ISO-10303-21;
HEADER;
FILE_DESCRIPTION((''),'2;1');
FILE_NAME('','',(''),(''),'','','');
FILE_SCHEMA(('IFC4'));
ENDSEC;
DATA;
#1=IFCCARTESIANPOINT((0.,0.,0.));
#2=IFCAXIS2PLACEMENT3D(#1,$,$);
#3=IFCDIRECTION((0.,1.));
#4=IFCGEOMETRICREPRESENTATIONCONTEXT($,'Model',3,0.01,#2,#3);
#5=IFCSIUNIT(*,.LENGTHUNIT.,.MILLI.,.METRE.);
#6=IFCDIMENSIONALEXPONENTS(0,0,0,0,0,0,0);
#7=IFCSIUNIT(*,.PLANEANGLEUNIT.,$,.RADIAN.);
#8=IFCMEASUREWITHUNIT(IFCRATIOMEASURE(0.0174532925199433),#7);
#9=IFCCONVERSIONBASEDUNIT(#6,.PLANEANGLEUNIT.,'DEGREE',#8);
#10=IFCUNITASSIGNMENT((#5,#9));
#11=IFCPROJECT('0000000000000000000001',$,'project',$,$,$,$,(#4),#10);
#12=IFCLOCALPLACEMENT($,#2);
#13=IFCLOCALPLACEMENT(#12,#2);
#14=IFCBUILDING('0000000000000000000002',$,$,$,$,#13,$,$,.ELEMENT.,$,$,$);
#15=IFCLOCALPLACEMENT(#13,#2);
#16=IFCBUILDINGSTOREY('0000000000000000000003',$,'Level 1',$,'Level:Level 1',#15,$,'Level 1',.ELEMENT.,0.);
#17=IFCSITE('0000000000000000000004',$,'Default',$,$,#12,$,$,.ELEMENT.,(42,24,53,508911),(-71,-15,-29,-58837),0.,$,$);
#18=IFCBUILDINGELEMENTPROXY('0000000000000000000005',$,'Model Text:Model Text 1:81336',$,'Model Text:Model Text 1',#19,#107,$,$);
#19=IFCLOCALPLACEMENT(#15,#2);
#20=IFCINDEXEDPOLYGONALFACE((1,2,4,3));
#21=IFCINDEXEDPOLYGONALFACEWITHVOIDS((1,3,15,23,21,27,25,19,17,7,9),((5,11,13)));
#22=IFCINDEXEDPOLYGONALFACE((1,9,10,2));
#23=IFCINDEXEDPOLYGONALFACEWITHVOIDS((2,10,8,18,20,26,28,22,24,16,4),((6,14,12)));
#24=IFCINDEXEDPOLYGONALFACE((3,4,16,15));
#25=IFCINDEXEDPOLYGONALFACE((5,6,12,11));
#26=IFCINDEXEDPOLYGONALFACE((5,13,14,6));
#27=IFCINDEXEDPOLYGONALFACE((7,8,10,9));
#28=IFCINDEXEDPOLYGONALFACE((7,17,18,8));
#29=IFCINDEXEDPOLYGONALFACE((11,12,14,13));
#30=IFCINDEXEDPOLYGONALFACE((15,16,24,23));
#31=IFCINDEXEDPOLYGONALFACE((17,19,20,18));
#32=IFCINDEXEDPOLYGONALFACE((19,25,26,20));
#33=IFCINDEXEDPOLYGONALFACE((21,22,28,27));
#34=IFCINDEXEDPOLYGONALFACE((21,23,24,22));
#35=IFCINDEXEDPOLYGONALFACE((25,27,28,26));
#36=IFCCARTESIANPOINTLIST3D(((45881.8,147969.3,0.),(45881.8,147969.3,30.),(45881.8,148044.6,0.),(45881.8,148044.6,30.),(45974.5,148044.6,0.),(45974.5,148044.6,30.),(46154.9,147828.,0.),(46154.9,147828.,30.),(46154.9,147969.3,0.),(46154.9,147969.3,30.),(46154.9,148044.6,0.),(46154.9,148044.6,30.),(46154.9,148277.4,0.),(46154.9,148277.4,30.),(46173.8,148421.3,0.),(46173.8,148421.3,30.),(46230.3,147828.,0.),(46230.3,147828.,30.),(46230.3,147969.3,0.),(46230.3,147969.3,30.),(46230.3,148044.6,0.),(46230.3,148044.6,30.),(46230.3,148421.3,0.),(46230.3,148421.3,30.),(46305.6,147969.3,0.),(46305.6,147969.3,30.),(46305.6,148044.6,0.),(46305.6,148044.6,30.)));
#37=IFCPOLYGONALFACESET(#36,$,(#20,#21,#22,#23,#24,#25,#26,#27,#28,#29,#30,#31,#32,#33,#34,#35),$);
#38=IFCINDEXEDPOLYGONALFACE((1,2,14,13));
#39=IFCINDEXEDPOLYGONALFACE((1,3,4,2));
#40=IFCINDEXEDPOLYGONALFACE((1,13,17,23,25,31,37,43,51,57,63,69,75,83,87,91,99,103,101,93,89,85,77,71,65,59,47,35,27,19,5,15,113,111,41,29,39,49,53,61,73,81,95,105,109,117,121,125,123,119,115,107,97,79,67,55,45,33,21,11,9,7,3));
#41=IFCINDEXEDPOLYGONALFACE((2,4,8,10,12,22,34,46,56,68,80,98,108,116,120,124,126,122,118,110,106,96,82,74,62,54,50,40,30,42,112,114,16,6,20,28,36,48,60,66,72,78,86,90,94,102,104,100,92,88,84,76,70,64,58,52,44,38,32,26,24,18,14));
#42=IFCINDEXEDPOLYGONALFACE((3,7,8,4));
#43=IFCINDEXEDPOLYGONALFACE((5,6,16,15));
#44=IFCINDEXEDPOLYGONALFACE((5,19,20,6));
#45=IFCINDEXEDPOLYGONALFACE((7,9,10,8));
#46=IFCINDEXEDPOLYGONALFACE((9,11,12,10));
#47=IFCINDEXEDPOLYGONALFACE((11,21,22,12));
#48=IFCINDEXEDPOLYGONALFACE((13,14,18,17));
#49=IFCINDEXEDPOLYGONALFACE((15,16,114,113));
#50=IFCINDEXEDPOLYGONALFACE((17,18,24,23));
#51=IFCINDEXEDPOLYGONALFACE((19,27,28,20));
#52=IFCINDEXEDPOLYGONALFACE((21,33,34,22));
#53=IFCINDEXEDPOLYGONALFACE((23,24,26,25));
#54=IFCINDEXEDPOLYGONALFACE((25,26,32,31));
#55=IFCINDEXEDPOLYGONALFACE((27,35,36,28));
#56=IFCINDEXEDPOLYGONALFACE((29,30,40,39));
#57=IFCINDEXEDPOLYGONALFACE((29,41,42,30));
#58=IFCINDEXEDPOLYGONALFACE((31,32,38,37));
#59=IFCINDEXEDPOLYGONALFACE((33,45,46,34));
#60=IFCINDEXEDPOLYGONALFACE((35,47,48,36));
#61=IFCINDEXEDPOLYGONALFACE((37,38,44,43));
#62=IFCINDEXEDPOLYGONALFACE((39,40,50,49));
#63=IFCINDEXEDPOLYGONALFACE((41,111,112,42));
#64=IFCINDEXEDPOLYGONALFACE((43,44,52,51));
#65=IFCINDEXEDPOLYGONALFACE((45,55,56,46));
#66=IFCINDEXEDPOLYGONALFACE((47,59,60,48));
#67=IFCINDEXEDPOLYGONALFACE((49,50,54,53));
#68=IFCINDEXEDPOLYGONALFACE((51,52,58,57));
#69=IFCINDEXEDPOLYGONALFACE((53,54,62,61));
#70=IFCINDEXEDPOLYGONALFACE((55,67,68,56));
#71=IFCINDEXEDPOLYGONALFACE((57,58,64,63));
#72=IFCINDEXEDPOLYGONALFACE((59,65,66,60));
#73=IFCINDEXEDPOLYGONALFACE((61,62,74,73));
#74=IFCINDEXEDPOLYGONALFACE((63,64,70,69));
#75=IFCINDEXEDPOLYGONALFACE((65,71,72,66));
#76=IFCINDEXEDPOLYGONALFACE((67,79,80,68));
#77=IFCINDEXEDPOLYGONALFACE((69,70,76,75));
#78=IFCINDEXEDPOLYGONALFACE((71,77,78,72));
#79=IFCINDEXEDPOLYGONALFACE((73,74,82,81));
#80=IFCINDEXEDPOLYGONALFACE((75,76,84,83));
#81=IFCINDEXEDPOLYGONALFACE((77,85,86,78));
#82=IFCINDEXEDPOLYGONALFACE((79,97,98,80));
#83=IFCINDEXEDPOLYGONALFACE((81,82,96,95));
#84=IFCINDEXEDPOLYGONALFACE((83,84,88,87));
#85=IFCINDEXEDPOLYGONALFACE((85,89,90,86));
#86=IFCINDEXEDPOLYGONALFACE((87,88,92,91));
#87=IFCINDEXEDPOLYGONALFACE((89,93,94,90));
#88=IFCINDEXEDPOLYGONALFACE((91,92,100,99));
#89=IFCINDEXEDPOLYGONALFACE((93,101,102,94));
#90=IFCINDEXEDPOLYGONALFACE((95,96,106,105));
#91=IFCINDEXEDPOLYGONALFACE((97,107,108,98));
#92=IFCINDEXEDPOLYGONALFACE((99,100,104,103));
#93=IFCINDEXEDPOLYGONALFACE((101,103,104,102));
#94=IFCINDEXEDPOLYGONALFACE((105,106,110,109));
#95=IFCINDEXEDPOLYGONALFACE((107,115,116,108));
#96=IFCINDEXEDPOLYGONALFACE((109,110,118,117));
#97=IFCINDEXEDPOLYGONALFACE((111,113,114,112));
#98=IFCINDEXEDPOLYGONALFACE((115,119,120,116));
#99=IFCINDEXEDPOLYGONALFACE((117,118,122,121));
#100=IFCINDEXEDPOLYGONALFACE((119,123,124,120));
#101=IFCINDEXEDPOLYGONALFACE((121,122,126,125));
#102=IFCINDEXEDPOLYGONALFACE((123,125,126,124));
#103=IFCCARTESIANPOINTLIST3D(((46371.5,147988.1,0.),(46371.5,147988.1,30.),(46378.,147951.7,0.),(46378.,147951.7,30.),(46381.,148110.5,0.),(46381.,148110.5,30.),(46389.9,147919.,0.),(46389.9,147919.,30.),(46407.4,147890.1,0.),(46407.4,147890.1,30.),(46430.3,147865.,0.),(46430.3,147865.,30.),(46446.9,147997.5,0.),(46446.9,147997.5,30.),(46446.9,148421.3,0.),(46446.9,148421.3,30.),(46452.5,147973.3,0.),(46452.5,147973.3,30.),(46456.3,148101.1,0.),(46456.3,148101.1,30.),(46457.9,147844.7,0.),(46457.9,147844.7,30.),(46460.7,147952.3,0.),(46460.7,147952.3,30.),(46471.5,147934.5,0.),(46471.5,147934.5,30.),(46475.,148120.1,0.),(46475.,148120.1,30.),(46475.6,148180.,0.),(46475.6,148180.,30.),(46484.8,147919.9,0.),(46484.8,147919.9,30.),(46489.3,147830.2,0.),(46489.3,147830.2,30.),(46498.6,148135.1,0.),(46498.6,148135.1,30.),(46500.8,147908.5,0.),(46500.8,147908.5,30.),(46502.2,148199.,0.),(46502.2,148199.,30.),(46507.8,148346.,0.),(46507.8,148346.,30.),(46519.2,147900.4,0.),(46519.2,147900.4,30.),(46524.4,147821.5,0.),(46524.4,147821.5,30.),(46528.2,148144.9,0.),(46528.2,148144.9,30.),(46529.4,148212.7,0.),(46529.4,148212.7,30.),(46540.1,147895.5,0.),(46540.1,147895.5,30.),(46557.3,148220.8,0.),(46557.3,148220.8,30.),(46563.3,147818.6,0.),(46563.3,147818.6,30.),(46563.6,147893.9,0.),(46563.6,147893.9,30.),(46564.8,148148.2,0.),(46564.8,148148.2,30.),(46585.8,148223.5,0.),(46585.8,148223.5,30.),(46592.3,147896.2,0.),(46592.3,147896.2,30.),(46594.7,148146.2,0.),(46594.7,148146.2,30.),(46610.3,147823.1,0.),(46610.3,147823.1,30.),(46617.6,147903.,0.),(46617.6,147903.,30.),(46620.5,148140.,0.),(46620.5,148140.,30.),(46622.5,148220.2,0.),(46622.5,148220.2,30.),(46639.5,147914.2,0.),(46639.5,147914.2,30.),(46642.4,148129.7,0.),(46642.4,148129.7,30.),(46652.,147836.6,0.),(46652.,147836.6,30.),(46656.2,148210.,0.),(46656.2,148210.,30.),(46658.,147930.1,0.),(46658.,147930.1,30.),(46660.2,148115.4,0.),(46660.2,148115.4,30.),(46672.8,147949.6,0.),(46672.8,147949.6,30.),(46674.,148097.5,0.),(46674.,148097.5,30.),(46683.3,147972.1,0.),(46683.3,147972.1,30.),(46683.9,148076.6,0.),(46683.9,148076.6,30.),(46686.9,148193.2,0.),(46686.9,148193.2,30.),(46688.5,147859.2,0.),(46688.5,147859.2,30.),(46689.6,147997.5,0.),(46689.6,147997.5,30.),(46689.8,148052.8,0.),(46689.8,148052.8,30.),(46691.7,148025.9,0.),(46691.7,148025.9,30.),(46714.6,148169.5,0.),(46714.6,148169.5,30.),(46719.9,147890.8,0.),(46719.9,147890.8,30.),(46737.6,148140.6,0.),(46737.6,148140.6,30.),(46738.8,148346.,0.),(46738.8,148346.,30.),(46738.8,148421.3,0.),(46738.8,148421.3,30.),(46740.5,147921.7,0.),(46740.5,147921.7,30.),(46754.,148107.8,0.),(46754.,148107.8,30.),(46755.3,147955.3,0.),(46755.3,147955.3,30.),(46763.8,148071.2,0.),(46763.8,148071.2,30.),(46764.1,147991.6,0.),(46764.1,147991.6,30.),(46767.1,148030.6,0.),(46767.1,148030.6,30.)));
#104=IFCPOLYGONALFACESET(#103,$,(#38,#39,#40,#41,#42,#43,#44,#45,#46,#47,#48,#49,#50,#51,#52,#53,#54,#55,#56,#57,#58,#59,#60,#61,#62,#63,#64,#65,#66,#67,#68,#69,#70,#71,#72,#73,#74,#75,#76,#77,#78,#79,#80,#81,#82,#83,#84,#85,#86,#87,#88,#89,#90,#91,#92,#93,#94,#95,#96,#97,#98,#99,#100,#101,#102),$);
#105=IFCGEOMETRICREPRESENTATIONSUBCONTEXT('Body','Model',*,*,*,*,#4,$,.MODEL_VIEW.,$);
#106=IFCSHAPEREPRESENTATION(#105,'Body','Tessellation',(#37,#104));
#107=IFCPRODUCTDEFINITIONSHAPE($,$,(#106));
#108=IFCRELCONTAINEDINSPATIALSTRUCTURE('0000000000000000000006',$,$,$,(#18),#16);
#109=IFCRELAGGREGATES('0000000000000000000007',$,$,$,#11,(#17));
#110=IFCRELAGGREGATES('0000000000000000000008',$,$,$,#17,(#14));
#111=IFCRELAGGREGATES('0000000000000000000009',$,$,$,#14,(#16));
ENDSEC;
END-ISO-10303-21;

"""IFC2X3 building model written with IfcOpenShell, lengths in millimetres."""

from ifc_helpers import new_model, entity, si_unit, converted_unit, direction, frame, origin, place, context, subcontext, project, spatial, polyline, outline, extrude, element, save


model = new_model("IFC2X3")

# Units and contexts
model_context = context("Model", 3, precision=0.01, world=origin(), true_north=direction((0.0, 1.0)))
body_context = subcontext(model_context, "Body", "Model", "MODEL_VIEW")
ifc_project = project(units=[si_unit("LENGTHUNIT", "METRE", prefix="MILLI"), converted_unit("PLANEANGLEUNIT", "DEGREE", entity("IfcRatioMeasure", 0.0174532925199433), si_unit("PLANEANGLEUNIT", "RADIAN"), dimensions=[0, 0, 0, 0, 0, 0, 0])], contexts=[model_context])

# Site, building, storey
site_placement = place(None, origin())
site = spatial("IfcSite", under=ifc_project, at=site_placement, Name="Default", CompositionType="ELEMENT", RefLatitude=(42, 24, 53, 508911), RefLongitude=(-71, -15, -29, -58837), RefElevation=0.0)
building_placement = place(site_placement, origin())
building = spatial("IfcBuilding", under=site, at=building_placement, CompositionType="ELEMENT")
storey_placement = place(building_placement, origin())
storey = spatial("IfcBuildingStorey", under=building, at=storey_placement, Name="Level 1", ObjectType="Level:Level 1", LongName="Level 1", CompositionType="ELEMENT", Elevation=0.0)

# Building element proxy
proxy_1_placement = place(storey_placement, origin())
element("IfcBuildingElementProxy", 1, at=proxy_1_placement, inside=storey, Name="Model Text:Model Text 1:81336", ObjectType="Model Text:Model Text 1", context=body_context, shape_type="SweptSolid", body=[
    extrude(outline(polyline([(-6.8, -218.3), (68.5, -218.3), (68.5, -77.1), (143.8, -77.1), (143.8, -1.7), (68.5, -1.7), (68.5, 375.0), (12.0, 375.0), (-280.0, -1.7), (-280.0, -77.1), (-6.8, -77.1), (-6.8, -218.3)]), holes=[polyline([(-6.8, -1.7), (-187.3, -1.7), (-6.8, 231.1), (-6.8, -1.7)])]), frame((46161.8, 148046.3, 0.0)), (0.0, 0.0, 1.0), 30.0),
    extrude(outline(polyline([(12.1, -219.3), (49.1, -219.3), (83.4, -213.2), (114.8, -201.1), (143.5, -182.8), (168.3, -159.2), (188.1, -130.8), (202.8, -97.8), (212.4, -60.0), (216.1, -12.9), (210.0, 30.5), (194.1, 70.4), (168.4, 106.8), (141.6, 132.5), (111.1, 152.9), (76.9, 167.9), (39.0, 177.6), (-1.5, 181.4), (-39.3, 178.1), (-74.4, 167.6), (-106.9, 150.1), (-135.0, 126.9), (-157.0, 99.6), (-172.8, 68.1), (-182.5, 32.6), (-184.8, 4.0), (-181.6, -24.8), (-172.9, -54.0), (-158.8, -83.5), (-316.6, -22.9), (-276.5, 204.6), (-350.7, 217.7), (-401.4, -69.8), (-106.8, -188.8), (-84.5, -116.2), (-99.9, -94.5), (-110.6, -68.6), (-115.1, -37.8), (-112.0, -1.2), (-104.8, 27.9), (-94.2, 52.3), (-80.3, 72.0), (-63.1, 87.0), (-43.0, 97.5), (-20.8, 103.6), (3.8, 105.3), (30.5, 102.6), (58.1, 95.6), (82.1, 84.9), (102.4, 70.6), (119.1, 52.7), (131.4, 31.7), (138.7, 8.2), (141.0, -17.9), (138.2, -46.6), (132.6, -69.4), (124.1, -89.2), (112.9, -105.9), (99.0, -119.6), (82.3, -130.2), (62.9, -137.7), (40.8, -142.2), (15.9, -143.5), (12.1, -219.3)])), frame((46585.4, 148038.2, 0.0), z_axis=(0.0, 0.0, 1.0), x_axis=(0.173842, -0.984774, 0.0)), (0.0, 0.0, 1.0), 30.0),
])

save(model, "model.ifc")
